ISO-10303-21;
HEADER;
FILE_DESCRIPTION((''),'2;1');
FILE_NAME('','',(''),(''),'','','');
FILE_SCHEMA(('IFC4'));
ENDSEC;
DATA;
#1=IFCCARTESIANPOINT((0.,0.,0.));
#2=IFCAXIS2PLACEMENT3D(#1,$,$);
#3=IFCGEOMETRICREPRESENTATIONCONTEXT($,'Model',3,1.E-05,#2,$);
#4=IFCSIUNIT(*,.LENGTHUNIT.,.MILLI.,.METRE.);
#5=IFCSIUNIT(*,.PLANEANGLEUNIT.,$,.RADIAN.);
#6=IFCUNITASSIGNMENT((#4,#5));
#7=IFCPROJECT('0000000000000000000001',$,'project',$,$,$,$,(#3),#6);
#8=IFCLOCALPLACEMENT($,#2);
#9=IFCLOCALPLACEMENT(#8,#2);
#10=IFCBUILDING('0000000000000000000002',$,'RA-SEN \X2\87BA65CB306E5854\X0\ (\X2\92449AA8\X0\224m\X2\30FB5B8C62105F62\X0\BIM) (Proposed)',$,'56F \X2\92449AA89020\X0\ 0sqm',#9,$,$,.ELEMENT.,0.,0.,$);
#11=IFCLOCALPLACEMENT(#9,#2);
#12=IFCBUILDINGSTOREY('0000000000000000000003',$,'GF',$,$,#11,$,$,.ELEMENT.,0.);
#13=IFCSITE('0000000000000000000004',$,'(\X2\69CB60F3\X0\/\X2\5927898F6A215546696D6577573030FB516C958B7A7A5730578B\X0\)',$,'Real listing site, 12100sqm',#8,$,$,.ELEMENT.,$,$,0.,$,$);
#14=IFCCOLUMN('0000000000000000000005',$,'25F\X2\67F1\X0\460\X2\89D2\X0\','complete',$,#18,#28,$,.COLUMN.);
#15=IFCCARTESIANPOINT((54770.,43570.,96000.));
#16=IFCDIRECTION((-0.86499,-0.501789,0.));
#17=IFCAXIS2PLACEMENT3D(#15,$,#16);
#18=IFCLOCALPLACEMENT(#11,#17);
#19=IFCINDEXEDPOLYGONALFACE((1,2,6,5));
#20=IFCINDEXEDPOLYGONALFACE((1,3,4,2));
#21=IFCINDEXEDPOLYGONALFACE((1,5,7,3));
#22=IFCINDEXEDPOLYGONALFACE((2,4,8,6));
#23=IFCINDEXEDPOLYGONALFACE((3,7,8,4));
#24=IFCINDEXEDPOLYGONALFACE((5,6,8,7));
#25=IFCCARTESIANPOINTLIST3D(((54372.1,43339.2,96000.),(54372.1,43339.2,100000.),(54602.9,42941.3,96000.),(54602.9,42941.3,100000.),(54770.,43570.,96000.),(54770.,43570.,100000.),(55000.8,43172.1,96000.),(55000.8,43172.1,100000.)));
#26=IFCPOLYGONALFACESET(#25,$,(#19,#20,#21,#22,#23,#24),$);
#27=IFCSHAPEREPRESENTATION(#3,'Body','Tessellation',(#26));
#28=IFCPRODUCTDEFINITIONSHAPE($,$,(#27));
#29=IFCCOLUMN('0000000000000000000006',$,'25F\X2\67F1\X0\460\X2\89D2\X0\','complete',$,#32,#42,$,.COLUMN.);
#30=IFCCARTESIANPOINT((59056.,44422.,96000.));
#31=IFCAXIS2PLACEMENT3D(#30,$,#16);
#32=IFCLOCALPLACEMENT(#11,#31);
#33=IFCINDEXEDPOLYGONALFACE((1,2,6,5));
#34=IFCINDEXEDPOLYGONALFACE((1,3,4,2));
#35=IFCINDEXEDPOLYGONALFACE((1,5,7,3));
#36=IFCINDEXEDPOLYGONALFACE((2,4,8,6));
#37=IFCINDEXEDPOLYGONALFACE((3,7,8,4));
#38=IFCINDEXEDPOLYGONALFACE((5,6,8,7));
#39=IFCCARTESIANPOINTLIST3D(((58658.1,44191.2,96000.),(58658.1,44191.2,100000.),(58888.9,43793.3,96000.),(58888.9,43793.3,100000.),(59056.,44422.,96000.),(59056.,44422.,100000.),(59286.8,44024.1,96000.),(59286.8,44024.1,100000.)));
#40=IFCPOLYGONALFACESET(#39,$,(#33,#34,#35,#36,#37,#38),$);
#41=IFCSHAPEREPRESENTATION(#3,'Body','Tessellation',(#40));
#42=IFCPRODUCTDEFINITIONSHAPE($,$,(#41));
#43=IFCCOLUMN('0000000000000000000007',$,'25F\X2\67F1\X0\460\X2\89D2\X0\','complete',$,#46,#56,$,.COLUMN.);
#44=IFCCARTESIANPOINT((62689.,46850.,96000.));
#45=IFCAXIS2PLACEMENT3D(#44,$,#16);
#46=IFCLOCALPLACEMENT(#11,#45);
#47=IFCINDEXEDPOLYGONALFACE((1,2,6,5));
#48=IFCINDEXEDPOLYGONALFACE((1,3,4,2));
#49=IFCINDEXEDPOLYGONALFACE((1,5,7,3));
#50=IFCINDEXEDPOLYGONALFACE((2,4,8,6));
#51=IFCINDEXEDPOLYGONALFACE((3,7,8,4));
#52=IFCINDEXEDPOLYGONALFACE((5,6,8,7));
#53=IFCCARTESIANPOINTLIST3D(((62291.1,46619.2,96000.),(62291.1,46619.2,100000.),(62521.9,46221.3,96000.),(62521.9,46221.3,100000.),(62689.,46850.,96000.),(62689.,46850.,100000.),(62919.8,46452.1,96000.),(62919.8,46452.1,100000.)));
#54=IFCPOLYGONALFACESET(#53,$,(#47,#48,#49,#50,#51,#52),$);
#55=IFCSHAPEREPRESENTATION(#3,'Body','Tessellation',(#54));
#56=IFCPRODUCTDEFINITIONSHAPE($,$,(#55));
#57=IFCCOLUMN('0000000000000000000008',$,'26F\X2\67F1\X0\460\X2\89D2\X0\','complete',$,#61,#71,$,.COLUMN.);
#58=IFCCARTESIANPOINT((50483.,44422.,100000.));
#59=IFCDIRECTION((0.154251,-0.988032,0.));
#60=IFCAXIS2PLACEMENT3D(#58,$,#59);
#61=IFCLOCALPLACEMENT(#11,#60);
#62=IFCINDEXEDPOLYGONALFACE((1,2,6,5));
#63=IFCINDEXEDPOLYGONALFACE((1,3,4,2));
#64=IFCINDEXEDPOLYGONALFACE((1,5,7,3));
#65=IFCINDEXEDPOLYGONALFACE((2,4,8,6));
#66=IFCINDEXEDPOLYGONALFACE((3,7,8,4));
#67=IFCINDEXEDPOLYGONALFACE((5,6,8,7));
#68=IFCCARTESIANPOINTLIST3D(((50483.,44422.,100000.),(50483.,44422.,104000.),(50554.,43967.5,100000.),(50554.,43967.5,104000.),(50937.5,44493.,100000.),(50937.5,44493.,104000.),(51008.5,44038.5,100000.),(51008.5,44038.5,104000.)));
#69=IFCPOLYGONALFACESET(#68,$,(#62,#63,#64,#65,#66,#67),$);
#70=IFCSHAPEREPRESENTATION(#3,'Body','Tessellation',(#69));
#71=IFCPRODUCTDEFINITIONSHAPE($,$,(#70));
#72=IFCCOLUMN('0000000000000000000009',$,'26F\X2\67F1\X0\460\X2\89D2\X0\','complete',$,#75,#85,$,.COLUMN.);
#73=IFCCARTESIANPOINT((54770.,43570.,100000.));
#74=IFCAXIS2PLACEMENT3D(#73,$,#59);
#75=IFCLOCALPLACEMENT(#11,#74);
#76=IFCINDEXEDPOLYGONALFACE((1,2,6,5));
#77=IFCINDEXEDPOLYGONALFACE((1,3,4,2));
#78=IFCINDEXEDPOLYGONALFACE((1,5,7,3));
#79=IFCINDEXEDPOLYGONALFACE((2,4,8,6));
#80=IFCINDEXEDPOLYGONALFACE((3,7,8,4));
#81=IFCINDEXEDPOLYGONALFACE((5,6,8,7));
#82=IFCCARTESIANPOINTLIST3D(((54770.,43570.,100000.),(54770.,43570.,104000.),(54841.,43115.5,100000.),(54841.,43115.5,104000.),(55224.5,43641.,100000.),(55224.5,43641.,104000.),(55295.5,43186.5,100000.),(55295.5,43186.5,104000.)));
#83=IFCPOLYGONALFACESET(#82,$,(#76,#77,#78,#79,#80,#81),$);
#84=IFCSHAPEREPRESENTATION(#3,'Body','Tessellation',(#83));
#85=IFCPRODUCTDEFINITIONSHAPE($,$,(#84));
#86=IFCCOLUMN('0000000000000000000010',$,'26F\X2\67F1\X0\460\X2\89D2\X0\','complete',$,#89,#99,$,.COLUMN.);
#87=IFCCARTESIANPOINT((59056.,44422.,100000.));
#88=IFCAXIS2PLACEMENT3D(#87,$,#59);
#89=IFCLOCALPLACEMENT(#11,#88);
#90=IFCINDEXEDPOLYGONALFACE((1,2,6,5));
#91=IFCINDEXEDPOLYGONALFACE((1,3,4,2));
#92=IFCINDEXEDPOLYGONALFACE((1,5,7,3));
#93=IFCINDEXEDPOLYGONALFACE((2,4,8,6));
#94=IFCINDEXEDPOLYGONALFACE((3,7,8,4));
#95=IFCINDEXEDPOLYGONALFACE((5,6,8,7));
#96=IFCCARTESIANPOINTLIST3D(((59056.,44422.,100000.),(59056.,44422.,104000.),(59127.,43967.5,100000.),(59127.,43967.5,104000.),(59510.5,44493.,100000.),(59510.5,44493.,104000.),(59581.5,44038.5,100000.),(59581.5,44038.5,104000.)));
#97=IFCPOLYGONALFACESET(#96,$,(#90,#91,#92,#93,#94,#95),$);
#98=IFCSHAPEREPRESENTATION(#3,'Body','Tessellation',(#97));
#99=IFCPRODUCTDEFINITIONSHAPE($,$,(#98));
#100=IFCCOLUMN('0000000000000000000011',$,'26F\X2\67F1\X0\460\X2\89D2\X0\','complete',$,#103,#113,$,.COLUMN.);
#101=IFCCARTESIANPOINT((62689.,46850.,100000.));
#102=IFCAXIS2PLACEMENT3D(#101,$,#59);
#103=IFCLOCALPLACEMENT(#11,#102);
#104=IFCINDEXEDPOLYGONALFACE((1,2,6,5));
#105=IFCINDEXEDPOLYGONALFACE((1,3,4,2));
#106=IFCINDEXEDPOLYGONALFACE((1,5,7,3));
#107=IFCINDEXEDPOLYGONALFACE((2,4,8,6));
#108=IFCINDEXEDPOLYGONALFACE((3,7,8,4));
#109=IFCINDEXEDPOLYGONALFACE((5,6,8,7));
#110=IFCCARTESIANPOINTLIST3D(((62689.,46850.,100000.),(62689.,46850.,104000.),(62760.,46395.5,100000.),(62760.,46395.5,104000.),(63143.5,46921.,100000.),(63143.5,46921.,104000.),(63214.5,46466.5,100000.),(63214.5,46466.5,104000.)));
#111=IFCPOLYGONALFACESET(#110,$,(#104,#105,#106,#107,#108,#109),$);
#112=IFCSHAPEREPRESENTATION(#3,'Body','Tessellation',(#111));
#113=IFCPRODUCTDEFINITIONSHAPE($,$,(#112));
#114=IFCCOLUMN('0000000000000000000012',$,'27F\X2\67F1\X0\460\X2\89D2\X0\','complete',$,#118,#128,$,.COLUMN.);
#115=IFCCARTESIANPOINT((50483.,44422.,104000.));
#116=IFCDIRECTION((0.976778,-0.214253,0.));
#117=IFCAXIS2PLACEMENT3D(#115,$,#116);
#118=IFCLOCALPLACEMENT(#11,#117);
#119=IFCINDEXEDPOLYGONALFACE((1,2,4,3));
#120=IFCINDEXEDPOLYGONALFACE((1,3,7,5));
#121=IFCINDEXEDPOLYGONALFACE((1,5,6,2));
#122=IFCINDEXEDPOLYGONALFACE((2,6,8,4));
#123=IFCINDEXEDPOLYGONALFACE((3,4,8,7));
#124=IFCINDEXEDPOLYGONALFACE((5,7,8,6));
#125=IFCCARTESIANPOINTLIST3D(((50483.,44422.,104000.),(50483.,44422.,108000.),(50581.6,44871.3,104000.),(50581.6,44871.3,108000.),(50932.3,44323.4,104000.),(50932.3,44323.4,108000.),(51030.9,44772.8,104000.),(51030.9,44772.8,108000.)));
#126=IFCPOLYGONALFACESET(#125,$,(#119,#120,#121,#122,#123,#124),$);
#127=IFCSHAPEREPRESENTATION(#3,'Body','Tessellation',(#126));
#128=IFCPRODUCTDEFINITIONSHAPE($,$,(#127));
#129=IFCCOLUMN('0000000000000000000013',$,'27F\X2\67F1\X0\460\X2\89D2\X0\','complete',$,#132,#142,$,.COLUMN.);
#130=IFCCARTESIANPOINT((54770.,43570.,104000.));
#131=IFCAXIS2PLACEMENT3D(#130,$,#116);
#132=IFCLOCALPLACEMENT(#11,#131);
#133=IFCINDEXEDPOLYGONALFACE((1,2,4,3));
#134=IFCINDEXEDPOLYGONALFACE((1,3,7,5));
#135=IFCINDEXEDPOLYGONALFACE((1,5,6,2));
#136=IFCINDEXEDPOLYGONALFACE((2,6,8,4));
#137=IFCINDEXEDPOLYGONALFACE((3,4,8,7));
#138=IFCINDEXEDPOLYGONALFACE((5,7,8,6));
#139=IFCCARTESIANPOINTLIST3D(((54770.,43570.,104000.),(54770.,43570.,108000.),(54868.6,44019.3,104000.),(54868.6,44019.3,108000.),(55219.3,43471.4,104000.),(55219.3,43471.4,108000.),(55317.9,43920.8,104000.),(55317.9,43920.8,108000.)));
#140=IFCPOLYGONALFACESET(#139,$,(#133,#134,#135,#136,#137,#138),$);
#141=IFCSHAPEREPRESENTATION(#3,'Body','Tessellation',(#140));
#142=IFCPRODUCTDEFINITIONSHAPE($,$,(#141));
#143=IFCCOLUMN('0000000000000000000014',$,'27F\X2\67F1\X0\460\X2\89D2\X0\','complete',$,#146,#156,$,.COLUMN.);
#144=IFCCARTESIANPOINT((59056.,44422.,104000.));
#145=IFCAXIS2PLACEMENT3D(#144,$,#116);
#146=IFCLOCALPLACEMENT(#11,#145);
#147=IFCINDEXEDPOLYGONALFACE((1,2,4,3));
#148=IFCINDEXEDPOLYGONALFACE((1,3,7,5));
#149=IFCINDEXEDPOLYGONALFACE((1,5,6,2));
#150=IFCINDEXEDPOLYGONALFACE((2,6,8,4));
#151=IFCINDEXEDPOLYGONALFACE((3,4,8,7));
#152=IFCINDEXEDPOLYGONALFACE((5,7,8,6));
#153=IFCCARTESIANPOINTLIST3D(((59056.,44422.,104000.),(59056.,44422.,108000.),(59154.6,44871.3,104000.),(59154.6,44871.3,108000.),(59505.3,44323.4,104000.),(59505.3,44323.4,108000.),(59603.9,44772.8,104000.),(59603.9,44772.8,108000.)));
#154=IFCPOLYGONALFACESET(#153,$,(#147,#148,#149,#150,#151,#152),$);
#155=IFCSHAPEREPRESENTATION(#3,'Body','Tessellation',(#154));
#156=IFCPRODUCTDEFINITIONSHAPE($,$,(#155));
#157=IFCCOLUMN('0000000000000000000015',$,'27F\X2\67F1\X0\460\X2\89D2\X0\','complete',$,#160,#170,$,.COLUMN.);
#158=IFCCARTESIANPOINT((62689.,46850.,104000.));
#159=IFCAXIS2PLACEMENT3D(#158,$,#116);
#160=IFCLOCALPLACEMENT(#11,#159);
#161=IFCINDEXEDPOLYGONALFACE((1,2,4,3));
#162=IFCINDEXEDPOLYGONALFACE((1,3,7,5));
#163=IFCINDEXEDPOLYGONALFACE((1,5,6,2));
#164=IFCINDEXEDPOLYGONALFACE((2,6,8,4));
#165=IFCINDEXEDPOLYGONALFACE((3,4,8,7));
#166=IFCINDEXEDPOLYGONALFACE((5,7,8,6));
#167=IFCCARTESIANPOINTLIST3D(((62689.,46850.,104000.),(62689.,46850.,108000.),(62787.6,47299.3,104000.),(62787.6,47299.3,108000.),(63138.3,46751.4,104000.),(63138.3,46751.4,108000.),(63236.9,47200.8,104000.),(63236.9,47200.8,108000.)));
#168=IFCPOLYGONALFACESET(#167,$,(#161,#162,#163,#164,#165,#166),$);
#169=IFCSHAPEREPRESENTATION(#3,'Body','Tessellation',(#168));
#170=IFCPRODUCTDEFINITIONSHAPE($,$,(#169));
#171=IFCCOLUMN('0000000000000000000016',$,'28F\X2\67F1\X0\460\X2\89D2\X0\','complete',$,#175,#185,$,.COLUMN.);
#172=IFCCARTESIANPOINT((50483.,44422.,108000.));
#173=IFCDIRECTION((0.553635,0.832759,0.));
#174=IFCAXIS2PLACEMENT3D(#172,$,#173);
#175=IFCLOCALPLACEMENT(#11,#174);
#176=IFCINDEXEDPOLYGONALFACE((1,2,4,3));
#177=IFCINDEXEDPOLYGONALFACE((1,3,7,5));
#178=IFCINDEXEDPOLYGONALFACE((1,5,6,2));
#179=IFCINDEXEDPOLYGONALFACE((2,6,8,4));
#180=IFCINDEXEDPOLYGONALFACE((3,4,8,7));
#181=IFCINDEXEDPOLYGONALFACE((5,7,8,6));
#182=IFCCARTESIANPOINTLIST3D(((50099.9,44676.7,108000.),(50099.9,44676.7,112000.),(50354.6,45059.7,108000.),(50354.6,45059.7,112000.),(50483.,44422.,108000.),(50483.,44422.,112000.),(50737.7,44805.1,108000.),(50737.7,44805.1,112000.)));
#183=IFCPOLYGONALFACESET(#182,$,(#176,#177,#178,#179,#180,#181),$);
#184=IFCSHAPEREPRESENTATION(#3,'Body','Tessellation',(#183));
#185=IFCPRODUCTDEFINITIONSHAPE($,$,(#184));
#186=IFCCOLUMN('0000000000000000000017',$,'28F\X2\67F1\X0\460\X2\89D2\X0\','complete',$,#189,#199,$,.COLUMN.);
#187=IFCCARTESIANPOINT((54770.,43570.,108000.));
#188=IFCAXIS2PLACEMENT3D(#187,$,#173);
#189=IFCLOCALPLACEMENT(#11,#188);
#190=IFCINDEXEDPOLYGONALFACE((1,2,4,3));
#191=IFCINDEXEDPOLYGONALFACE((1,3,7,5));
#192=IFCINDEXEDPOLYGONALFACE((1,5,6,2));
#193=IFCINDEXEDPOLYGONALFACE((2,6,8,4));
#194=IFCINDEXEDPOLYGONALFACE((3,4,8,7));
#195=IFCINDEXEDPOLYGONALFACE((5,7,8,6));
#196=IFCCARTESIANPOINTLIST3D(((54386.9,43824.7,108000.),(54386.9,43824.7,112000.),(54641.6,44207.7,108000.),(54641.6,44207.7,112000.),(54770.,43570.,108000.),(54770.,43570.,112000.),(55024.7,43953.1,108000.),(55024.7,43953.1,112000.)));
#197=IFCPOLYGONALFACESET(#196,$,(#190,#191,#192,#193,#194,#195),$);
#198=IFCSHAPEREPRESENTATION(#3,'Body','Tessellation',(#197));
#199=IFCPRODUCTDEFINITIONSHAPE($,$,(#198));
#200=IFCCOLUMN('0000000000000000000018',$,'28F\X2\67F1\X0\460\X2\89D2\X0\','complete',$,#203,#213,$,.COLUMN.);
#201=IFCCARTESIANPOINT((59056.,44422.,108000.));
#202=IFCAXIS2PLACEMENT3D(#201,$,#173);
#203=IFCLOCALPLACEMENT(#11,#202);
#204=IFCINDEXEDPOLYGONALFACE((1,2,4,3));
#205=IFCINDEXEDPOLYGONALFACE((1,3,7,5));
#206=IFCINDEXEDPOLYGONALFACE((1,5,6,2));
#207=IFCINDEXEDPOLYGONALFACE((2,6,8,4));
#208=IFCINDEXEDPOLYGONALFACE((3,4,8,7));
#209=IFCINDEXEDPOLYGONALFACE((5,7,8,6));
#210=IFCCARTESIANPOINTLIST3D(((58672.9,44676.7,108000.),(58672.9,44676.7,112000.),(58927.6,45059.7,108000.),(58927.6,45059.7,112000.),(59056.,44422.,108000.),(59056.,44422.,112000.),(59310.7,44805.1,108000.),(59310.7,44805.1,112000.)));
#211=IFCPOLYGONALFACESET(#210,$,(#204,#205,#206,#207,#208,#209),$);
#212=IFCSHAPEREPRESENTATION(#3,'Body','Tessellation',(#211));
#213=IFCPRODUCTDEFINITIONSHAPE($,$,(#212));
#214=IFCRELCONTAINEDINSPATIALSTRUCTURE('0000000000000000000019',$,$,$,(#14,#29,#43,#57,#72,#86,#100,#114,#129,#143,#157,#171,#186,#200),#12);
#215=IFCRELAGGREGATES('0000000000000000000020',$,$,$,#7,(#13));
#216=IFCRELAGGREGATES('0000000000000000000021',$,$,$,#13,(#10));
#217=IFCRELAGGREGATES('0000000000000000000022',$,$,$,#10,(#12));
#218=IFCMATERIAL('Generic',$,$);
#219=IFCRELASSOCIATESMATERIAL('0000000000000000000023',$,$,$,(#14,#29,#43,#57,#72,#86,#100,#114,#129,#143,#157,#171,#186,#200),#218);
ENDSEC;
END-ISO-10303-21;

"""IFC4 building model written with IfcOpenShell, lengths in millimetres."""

from ifc_helpers import new_model, si_unit, frame, frame_2d, origin, place, context, project, spatial, rectangle, extrude, material, element, save


model = new_model("IFC4")

# Units and contexts
model_context = context("Model", 3, precision=1e-05, world=origin())
ifc_project = project(units=[si_unit("LENGTHUNIT", "METRE", prefix="MILLI"), si_unit("PLANEANGLEUNIT", "RADIAN")], contexts=[model_context])

# Site, building, storey
site_placement = place(None, origin())
site = spatial("IfcSite", under=ifc_project, at=site_placement, Name="(構想/大規模商業敷地・公開空地型)", ObjectType="Real listing site, 12100sqm", CompositionType="ELEMENT", RefElevation=0.0)
building_placement = place(site_placement, origin())
building = spatial("IfcBuilding", under=site, at=building_placement, Name="RA-SEN 螺旋の塔 (鉄骨224m・完成形BIM) (Proposed)", ObjectType="56F 鉄骨造 0sqm", CompositionType="ELEMENT", ElevationOfRefHeight=0.0, ElevationOfTerrain=0.0)
storey_placement = place(building_placement, origin())
storey = spatial("IfcBuildingStorey", under=building, at=storey_placement, Name="GF", CompositionType="ELEMENT", Elevation=0.0)

# Columns
ifc_material = material(Name="Generic")
column_1_placement = place(storey_placement, frame((54770.0, 43570.0, 96000.0), x_axis=(-0.86499, -0.501789, 0.0)))
element("IfcColumn", 1, at=column_1_placement, inside=storey, material=ifc_material, Name="25F柱460角", Description="complete", PredefinedType="COLUMN", context=model_context, shape_type="SweptSolid", body=[
    extrude(rectangle(XDim=460.0, YDim=460.0, at=frame_2d((230.0, 230.0))), frame((54770.0, 43570.0, 96000.0), x_axis=(-0.86499, -0.501789, 0.0)), (0.0, 0.0, 1.0), 4000.0),
])
column_2_placement = place(storey_placement, frame((59056.0, 44422.0, 96000.0), x_axis=(-0.86499, -0.501789, 0.0)))
element("IfcColumn", 2, at=column_2_placement, inside=storey, material=ifc_material, Name="25F柱460角", Description="complete", PredefinedType="COLUMN", context=model_context, shape_type="SweptSolid", body=[
    extrude(rectangle(XDim=460.0, YDim=460.0, at=frame_2d((230.0, 230.0))), frame((59056.0, 44422.0, 96000.0), x_axis=(-0.86499, -0.501789, 0.0)), (0.0, 0.0, 1.0), 4000.0),
])
column_3_placement = place(storey_placement, frame((62689.0, 46850.0, 96000.0), x_axis=(-0.86499, -0.501789, 0.0)))
element("IfcColumn", 3, at=column_3_placement, inside=storey, material=ifc_material, Name="25F柱460角", Description="complete", PredefinedType="COLUMN", context=model_context, shape_type="SweptSolid", body=[
    extrude(rectangle(XDim=460.0, YDim=460.0, at=frame_2d((230.0, 230.0))), frame((62689.0, 46850.0, 96000.0), x_axis=(-0.86499, -0.501789, 0.0)), (0.0, 0.0, 1.0), 4000.0),
])
column_4_placement = place(storey_placement, frame((50483.0, 44422.0, 100000.0), x_axis=(0.154251, -0.988032, 0.0)))
element("IfcColumn", 4, at=column_4_placement, inside=storey, material=ifc_material, Name="26F柱460角", Description="complete", PredefinedType="COLUMN", context=model_context, shape_type="SweptSolid", body=[
    extrude(rectangle(XDim=460.0, YDim=460.0, at=frame_2d((230.0, 230.0))), frame((50483.0, 44422.0, 100000.0), x_axis=(0.154251, -0.988032, 0.0)), (0.0, 0.0, 1.0), 4000.0),
])
column_5_placement = place(storey_placement, frame((54770.0, 43570.0, 100000.0), x_axis=(0.154251, -0.988032, 0.0)))
element("IfcColumn", 5, at=column_5_placement, inside=storey, material=ifc_material, Name="26F柱460角", Description="complete", PredefinedType="COLUMN", context=model_context, shape_type="SweptSolid", body=[
    extrude(rectangle(XDim=460.0, YDim=460.0, at=frame_2d((230.0, 230.0))), frame((54770.0, 43570.0, 100000.0), x_axis=(0.154251, -0.988032, 0.0)), (0.0, 0.0, 1.0), 4000.0),
])
column_6_placement = place(storey_placement, frame((59056.0, 44422.0, 100000.0), x_axis=(0.154251, -0.988032, 0.0)))
element("IfcColumn", 6, at=column_6_placement, inside=storey, material=ifc_material, Name="26F柱460角", Description="complete", PredefinedType="COLUMN", context=model_context, shape_type="SweptSolid", body=[
    extrude(rectangle(XDim=460.0, YDim=460.0, at=frame_2d((230.0, 230.0))), frame((59056.0, 44422.0, 100000.0), x_axis=(0.154251, -0.988032, 0.0)), (0.0, 0.0, 1.0), 4000.0),
])
column_7_placement = place(storey_placement, frame((62689.0, 46850.0, 100000.0), x_axis=(0.154251, -0.988032, 0.0)))
element("IfcColumn", 7, at=column_7_placement, inside=storey, material=ifc_material, Name="26F柱460角", Description="complete", PredefinedType="COLUMN", context=model_context, shape_type="SweptSolid", body=[
    extrude(rectangle(XDim=460.0, YDim=460.0, at=frame_2d((230.0, 230.0))), frame((62689.0, 46850.0, 100000.0), x_axis=(0.154251, -0.988032, 0.0)), (0.0, 0.0, 1.0), 4000.0),
])
column_8_placement = place(storey_placement, frame((50483.0, 44422.0, 104000.0), x_axis=(0.976778, -0.214253, 0.0)))
element("IfcColumn", 8, at=column_8_placement, inside=storey, material=ifc_material, Name="27F柱460角", Description="complete", PredefinedType="COLUMN", context=model_context, shape_type="SweptSolid", body=[
    extrude(rectangle(XDim=460.0, YDim=460.0, at=frame_2d((230.0, 230.0))), frame((50483.0, 44422.0, 104000.0), x_axis=(0.976778, -0.214253, 0.0)), (0.0, 0.0, 1.0), 4000.0),
])
column_9_placement = place(storey_placement, frame((54770.0, 43570.0, 104000.0), x_axis=(0.976778, -0.214253, 0.0)))
element("IfcColumn", 9, at=column_9_placement, inside=storey, material=ifc_material, Name="27F柱460角", Description="complete", PredefinedType="COLUMN", context=model_context, shape_type="SweptSolid", body=[
    extrude(rectangle(XDim=460.0, YDim=460.0, at=frame_2d((230.0, 230.0))), frame((54770.0, 43570.0, 104000.0), x_axis=(0.976778, -0.214253, 0.0)), (0.0, 0.0, 1.0), 4000.0),
])
column_10_placement = place(storey_placement, frame((59056.0, 44422.0, 104000.0), x_axis=(0.976778, -0.214253, 0.0)))
element("IfcColumn", 10, at=column_10_placement, inside=storey, material=ifc_material, Name="27F柱460角", Description="complete", PredefinedType="COLUMN", context=model_context, shape_type="SweptSolid", body=[
    extrude(rectangle(XDim=460.0, YDim=460.0, at=frame_2d((230.0, 230.0))), frame((59056.0, 44422.0, 104000.0), x_axis=(0.976778, -0.214253, 0.0)), (0.0, 0.0, 1.0), 4000.0),
])
column_11_placement = place(storey_placement, frame((62689.0, 46850.0, 104000.0), x_axis=(0.976778, -0.214253, 0.0)))
element("IfcColumn", 11, at=column_11_placement, inside=storey, material=ifc_material, Name="27F柱460角", Description="complete", PredefinedType="COLUMN", context=model_context, shape_type="SweptSolid", body=[
    extrude(rectangle(XDim=460.0, YDim=460.0, at=frame_2d((230.0, 230.0))), frame((62689.0, 46850.0, 104000.0), x_axis=(0.976778, -0.214253, 0.0)), (0.0, 0.0, 1.0), 4000.0),
])
column_12_placement = place(storey_placement, frame((50483.0, 44422.0, 108000.0), x_axis=(0.553635, 0.832759, 0.0)))
element("IfcColumn", 12, at=column_12_placement, inside=storey, material=ifc_material, Name="28F柱460角", Description="complete", PredefinedType="COLUMN", context=model_context, shape_type="SweptSolid", body=[
    extrude(rectangle(XDim=460.0, YDim=460.0, at=frame_2d((230.0, 230.0))), frame((50483.0, 44422.0, 108000.0), x_axis=(0.553635, 0.832759, 0.0)), (0.0, 0.0, 1.0), 4000.0),
])
column_13_placement = place(storey_placement, frame((54770.0, 43570.0, 108000.0), x_axis=(0.553635, 0.832759, 0.0)))
element("IfcColumn", 13, at=column_13_placement, inside=storey, material=ifc_material, Name="28F柱460角", Description="complete", PredefinedType="COLUMN", context=model_context, shape_type="SweptSolid", body=[
    extrude(rectangle(XDim=460.0, YDim=460.0, at=frame_2d((230.0, 230.0))), frame((54770.0, 43570.0, 108000.0), x_axis=(0.553635, 0.832759, 0.0)), (0.0, 0.0, 1.0), 4000.0),
])
column_14_placement = place(storey_placement, frame((59056.0, 44422.0, 108000.0), x_axis=(0.553635, 0.832759, 0.0)))
element("IfcColumn", 14, at=column_14_placement, inside=storey, material=ifc_material, Name="28F柱460角", Description="complete", PredefinedType="COLUMN", context=model_context, shape_type="SweptSolid", body=[
    extrude(rectangle(XDim=460.0, YDim=460.0, at=frame_2d((230.0, 230.0))), frame((59056.0, 44422.0, 108000.0), x_axis=(0.553635, 0.832759, 0.0)), (0.0, 0.0, 1.0), 4000.0),
])

save(model, "model.ifc")
